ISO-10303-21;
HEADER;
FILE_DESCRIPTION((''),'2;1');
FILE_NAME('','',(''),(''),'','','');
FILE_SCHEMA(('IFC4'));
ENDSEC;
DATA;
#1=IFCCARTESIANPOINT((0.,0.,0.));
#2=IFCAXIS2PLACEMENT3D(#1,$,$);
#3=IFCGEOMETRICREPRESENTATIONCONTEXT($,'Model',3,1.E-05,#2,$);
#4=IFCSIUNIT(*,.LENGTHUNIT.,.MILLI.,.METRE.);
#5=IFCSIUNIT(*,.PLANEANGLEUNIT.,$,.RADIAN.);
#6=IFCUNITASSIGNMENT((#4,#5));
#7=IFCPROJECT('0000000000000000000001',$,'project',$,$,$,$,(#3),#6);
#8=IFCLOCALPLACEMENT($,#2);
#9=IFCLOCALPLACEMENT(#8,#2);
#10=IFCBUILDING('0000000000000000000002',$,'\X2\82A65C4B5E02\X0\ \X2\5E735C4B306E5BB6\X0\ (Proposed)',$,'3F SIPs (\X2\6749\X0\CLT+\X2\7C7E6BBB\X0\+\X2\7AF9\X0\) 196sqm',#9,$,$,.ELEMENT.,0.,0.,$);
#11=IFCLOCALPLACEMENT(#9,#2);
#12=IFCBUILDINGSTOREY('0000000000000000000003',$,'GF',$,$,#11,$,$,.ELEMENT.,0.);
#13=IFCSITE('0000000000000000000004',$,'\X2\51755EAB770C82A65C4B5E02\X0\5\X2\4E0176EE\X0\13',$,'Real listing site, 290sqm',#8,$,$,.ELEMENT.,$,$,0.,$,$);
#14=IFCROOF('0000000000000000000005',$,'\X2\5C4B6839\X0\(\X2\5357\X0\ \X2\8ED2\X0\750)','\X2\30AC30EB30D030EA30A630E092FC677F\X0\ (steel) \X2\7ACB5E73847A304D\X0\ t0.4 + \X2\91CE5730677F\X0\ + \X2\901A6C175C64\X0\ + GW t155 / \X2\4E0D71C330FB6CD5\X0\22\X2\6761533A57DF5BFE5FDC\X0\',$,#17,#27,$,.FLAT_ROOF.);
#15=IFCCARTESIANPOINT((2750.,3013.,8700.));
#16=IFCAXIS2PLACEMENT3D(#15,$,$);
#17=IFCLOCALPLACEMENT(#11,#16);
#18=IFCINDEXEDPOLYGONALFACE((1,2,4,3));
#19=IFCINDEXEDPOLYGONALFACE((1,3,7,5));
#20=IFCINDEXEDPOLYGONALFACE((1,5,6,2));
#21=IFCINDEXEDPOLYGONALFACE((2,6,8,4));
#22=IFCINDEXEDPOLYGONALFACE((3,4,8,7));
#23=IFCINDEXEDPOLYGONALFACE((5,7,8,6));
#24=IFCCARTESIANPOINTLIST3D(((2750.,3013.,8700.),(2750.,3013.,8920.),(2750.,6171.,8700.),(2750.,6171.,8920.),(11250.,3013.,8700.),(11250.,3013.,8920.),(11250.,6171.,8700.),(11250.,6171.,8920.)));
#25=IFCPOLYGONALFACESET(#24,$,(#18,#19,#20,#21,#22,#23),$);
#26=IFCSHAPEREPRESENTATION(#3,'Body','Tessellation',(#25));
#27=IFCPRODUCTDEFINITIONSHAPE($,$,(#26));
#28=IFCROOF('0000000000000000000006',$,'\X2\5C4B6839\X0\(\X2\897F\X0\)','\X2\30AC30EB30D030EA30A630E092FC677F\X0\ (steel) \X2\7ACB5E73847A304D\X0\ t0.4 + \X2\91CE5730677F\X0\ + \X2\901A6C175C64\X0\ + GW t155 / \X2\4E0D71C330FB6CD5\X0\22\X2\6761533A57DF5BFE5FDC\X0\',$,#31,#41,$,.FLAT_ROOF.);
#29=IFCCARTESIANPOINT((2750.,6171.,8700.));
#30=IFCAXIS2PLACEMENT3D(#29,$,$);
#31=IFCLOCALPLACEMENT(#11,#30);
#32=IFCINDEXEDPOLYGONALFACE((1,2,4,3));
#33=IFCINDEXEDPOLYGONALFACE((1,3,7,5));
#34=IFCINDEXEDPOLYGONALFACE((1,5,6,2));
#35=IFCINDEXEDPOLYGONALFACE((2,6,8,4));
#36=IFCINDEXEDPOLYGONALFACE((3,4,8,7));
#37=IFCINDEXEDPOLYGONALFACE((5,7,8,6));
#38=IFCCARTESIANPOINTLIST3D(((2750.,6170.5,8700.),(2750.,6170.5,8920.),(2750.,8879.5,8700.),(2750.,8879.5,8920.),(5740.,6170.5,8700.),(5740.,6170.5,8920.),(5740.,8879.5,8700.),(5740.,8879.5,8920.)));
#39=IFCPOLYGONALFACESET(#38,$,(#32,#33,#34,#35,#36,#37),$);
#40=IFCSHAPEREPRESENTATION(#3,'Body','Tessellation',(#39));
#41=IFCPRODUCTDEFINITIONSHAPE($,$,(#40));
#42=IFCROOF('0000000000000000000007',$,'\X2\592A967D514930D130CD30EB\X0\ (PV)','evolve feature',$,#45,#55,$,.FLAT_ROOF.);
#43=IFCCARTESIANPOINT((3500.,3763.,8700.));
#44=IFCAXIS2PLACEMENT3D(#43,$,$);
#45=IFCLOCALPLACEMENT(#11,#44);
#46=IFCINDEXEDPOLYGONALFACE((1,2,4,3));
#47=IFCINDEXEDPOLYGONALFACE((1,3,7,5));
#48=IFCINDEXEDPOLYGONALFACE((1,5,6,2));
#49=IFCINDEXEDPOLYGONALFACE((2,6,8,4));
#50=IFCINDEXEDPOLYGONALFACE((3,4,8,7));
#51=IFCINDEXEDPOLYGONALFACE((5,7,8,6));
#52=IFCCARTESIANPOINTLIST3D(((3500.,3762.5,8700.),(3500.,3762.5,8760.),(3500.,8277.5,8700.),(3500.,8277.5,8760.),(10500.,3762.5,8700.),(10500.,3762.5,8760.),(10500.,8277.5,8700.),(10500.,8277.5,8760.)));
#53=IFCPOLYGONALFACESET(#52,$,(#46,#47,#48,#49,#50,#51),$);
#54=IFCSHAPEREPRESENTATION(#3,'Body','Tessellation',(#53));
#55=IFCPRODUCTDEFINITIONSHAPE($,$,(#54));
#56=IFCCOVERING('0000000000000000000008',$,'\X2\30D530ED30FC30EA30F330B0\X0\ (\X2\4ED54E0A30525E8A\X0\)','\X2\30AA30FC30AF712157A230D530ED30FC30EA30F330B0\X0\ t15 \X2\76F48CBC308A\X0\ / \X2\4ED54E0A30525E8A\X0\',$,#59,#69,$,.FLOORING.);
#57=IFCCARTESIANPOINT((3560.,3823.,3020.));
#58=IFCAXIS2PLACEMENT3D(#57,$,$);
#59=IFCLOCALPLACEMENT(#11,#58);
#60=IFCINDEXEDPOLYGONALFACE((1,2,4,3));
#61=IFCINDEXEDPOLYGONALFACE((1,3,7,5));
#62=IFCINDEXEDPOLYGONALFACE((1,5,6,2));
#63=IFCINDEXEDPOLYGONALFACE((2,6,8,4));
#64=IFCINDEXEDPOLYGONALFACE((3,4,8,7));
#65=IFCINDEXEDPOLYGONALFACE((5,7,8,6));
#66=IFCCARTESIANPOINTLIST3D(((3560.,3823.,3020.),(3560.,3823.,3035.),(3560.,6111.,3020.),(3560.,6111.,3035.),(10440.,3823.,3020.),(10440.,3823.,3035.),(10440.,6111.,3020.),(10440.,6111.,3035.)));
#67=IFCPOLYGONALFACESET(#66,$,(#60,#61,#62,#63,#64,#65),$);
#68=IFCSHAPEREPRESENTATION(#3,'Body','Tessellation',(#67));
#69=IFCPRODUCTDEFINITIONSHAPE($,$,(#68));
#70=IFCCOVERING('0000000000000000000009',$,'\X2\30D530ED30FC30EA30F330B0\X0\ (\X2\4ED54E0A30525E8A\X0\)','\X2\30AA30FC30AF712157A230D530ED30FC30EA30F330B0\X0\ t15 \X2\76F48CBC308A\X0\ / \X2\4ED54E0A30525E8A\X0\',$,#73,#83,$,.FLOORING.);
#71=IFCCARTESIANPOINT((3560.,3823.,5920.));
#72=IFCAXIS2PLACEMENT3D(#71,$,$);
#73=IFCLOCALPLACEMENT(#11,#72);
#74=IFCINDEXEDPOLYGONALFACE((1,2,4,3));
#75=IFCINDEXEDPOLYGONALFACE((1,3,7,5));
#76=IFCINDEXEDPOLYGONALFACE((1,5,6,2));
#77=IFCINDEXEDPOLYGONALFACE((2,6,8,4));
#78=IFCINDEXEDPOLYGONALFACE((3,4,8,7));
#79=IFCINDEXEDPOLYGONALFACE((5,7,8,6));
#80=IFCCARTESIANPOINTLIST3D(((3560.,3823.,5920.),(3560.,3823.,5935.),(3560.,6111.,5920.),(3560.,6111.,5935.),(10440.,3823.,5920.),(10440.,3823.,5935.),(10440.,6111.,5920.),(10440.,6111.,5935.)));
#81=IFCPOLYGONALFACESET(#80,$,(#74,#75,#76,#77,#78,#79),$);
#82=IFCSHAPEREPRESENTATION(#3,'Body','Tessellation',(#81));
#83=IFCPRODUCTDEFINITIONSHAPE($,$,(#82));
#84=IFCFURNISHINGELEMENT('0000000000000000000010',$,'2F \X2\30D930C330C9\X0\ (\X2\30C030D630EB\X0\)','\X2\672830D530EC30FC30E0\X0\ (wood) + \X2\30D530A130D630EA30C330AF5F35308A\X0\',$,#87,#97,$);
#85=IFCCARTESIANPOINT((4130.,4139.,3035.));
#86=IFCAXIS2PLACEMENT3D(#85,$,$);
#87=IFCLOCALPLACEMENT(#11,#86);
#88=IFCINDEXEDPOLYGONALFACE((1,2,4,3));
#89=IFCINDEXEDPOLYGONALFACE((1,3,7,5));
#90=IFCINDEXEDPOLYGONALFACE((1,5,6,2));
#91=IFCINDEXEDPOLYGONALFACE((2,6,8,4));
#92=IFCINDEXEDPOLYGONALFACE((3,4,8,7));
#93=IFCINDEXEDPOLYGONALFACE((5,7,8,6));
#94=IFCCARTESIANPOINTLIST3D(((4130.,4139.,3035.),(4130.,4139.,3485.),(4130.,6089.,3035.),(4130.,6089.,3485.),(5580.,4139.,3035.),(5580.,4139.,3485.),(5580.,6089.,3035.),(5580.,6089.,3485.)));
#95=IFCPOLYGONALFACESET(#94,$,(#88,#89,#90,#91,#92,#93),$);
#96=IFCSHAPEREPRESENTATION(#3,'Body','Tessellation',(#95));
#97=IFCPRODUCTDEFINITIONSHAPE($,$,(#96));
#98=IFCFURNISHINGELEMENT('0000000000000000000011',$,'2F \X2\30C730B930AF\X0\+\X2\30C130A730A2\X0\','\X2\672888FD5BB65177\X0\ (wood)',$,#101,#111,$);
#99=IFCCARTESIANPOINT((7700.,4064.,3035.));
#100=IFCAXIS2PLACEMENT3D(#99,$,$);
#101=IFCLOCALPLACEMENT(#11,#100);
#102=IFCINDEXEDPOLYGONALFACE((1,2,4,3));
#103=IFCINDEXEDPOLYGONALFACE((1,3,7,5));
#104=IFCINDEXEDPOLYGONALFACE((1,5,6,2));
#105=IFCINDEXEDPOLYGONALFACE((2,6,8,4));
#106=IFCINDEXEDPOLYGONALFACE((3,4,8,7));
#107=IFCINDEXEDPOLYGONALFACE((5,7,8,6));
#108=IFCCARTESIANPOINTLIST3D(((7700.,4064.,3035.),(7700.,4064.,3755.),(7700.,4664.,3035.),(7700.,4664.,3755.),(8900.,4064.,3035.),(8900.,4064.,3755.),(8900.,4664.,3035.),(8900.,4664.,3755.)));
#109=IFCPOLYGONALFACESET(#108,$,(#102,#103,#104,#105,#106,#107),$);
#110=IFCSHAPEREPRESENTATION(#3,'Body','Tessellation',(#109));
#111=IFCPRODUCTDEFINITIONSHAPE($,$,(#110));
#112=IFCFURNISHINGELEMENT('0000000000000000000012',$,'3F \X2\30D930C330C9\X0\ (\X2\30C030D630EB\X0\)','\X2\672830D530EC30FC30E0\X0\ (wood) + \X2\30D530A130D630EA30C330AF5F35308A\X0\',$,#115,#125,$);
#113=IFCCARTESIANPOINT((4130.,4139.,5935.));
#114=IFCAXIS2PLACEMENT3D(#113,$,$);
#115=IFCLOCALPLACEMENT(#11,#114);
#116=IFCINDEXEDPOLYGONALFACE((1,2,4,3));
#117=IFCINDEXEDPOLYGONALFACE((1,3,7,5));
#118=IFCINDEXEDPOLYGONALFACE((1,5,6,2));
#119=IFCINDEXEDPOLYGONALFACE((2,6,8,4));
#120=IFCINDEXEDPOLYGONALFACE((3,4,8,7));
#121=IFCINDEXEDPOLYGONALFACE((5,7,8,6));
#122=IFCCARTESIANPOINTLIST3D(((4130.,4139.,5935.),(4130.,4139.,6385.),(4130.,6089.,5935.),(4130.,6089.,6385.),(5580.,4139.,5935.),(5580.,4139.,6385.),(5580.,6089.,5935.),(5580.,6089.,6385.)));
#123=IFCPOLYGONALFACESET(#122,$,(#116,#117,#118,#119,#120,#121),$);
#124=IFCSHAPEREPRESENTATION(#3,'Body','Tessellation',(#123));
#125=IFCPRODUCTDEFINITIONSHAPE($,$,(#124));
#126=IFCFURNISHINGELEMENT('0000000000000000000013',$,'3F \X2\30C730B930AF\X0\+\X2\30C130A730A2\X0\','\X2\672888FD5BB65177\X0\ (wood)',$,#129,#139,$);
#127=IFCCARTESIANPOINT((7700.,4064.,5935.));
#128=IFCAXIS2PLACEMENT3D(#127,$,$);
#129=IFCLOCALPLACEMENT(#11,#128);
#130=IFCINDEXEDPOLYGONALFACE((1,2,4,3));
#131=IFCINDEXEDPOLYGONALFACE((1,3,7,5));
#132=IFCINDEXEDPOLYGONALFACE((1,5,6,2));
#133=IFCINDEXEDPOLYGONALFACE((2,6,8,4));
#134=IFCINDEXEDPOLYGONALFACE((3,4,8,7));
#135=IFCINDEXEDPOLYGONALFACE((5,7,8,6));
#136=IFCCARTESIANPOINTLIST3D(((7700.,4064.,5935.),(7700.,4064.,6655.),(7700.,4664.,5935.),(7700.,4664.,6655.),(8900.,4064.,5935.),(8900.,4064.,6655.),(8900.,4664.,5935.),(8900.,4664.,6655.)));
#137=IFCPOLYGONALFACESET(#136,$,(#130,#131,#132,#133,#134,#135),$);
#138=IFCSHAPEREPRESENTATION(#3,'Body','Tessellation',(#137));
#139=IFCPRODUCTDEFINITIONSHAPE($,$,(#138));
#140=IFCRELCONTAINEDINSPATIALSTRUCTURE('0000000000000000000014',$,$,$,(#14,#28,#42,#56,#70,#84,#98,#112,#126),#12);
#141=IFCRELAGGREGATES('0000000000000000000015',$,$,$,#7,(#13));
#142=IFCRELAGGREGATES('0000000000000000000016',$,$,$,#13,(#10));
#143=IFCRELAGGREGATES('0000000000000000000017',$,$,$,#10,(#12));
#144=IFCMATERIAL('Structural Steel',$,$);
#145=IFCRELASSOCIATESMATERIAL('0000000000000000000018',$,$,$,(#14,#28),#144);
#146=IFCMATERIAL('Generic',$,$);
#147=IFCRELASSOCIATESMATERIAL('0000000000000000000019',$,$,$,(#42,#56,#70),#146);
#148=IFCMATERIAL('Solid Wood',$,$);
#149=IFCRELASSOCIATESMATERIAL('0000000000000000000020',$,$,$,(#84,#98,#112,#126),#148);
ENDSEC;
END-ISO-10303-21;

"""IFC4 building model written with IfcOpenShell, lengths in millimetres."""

from ifc_helpers import new_model, si_unit, frame, frame_2d, origin, place, context, project, spatial, rectangle, extrude, material, element, save


model = new_model("IFC4")

# Units and contexts
model_context = context("Model", 3, precision=1e-05, world=origin())
ifc_project = project(units=[si_unit("LENGTHUNIT", "METRE", prefix="MILLI"), si_unit("PLANEANGLEUNIT", "RADIAN")], contexts=[model_context])

# Site, building, storey
site_placement = place(None, origin())
site = spatial("IfcSite", under=ifc_project, at=site_placement, Name="兵庫県芦屋市5丁目13", ObjectType="Real listing site, 290sqm", CompositionType="ELEMENT", RefElevation=0.0)
building_placement = place(site_placement, origin())
building = spatial("IfcBuilding", under=site, at=building_placement, Name="芦屋市 平屋の家 (Proposed)", ObjectType="3F SIPs (杉CLT+籾殻+竹) 196sqm", CompositionType="ELEMENT", ElevationOfRefHeight=0.0, ElevationOfTerrain=0.0)
storey_placement = place(building_placement, origin())
storey = spatial("IfcBuildingStorey", under=building, at=storey_placement, Name="GF", CompositionType="ELEMENT", Elevation=0.0)

# Shared definitions
ifc_material_1 = material(Name="Solid Wood")

# Roofs
ifc_material_2 = material(Name="Structural Steel")
roof_1_placement = place(storey_placement, frame((2750.0, 3013.0, 8700.0)))
element("IfcRoof", 1, at=roof_1_placement, inside=storey, material=ifc_material_2, Name="屋根(南 軒750)", Description="ガルバリウム鋼板 (steel) 立平葺き t0.4 + 野地板 + 通気層 + GW t155 / 不燃・法22条区域対応", PredefinedType="FLAT_ROOF", context=model_context, shape_type="SweptSolid", body=[
    extrude(rectangle(XDim=8500.0, YDim=3158.0, at=frame_2d((4250.0, 1579.0))), frame((2750.0, 3013.0, 8700.0)), (0.0, 0.0, 1.0), 220.0),
])
roof_2_placement = place(storey_placement, frame((2750.0, 6171.0, 8700.0)))
element("IfcRoof", 2, at=roof_2_placement, inside=storey, material=ifc_material_2, Name="屋根(西)", Description="ガルバリウム鋼板 (steel) 立平葺き t0.4 + 野地板 + 通気層 + GW t155 / 不燃・法22条区域対応", PredefinedType="FLAT_ROOF", context=model_context, shape_type="SweptSolid", body=[
    extrude(rectangle(XDim=2990.0, YDim=2709.0, at=frame_2d((1495.0, 1354.0))), frame((2750.0, 6171.0, 8700.0)), (0.0, 0.0, 1.0), 220.0),
])
ifc_material_3 = material(Name="Generic")
roof_3_placement = place(storey_placement, frame((3500.0, 3763.0, 8700.0)))
element("IfcRoof", 3, at=roof_3_placement, inside=storey, material=ifc_material_3, Name="太陽光パネル (PV)", Description="evolve feature", PredefinedType="FLAT_ROOF", context=model_context, shape_type="SweptSolid", body=[
    extrude(rectangle(XDim=7000.0, YDim=4515.0, at=frame_2d((3500.0, 2257.0))), frame((3500.0, 3763.0, 8700.0)), (0.0, 0.0, 1.0), 60.0),
])

# Coverings
covering_1_placement = place(storey_placement, frame((3560.0, 3823.0, 3020.0)))
element("IfcCovering", 4, at=covering_1_placement, inside=storey, material=ifc_material_3, Name="フローリング (仕上げ床)", Description="オーク無垢フローリング t15 直貼り / 仕上げ床", PredefinedType="FLOORING", context=model_context, shape_type="SweptSolid", body=[
    extrude(rectangle(XDim=6880.0, YDim=2288.0, at=frame_2d((3440.0, 1144.0))), frame((3560.0, 3823.0, 3020.0)), (0.0, 0.0, 1.0), 15.0),
])
covering_2_placement = place(storey_placement, frame((3560.0, 3823.0, 5920.0)))
element("IfcCovering", 5, at=covering_2_placement, inside=storey, material=ifc_material_3, Name="フローリング (仕上げ床)", Description="オーク無垢フローリング t15 直貼り / 仕上げ床", PredefinedType="FLOORING", context=model_context, shape_type="SweptSolid", body=[
    extrude(rectangle(XDim=6880.0, YDim=2288.0, at=frame_2d((3440.0, 1144.0))), frame((3560.0, 3823.0, 5920.0)), (0.0, 0.0, 1.0), 15.0),
])

# Furnishing elements
furnishing_1_placement = place(storey_placement, frame((4130.0, 4139.0, 3035.0)))
element("IfcFurnishingElement", 6, at=furnishing_1_placement, inside=storey, material=ifc_material_1, Name="2F ベッド (ダブル)", Description="木フレーム (wood) + ファブリック張り", context=model_context, shape_type="SweptSolid", body=[
    extrude(rectangle(XDim=1450.0, YDim=1950.0, at=frame_2d((725.0, 975.0))), frame((4130.0, 4139.0, 3035.0)), (0.0, 0.0, 1.0), 450.0),
])
furnishing_2_placement = place(storey_placement, frame((7700.0, 4064.0, 3035.0)))
element("IfcFurnishingElement", 7, at=furnishing_2_placement, inside=storey, material=ifc_material_1, Name="2F デスク+チェア", Description="木製家具 (wood)", context=model_context, shape_type="SweptSolid", body=[
    extrude(rectangle(XDim=1200.0, YDim=600.0, at=frame_2d((600.0, 300.0))), frame((7700.0, 4064.0, 3035.0)), (0.0, 0.0, 1.0), 720.0),
])
furnishing_3_placement = place(storey_placement, frame((4130.0, 4139.0, 5935.0)))
element("IfcFurnishingElement", 8, at=furnishing_3_placement, inside=storey, material=ifc_material_1, Name="3F ベッド (ダブル)", Description="木フレーム (wood) + ファブリック張り", context=model_context, shape_type="SweptSolid", body=[
    extrude(rectangle(XDim=1450.0, YDim=1950.0, at=frame_2d((725.0, 975.0))), frame((4130.0, 4139.0, 5935.0)), (0.0, 0.0, 1.0), 450.0),
])
furnishing_4_placement = place(storey_placement, frame((7700.0, 4064.0, 5935.0)))
element("IfcFurnishingElement", 9, at=furnishing_4_placement, inside=storey, material=ifc_material_1, Name="3F デスク+チェア", Description="木製家具 (wood)", context=model_context, shape_type="SweptSolid", body=[
    extrude(rectangle(XDim=1200.0, YDim=600.0, at=frame_2d((600.0, 300.0))), frame((7700.0, 4064.0, 5935.0)), (0.0, 0.0, 1.0), 720.0),
])

save(model, "model.ifc")
